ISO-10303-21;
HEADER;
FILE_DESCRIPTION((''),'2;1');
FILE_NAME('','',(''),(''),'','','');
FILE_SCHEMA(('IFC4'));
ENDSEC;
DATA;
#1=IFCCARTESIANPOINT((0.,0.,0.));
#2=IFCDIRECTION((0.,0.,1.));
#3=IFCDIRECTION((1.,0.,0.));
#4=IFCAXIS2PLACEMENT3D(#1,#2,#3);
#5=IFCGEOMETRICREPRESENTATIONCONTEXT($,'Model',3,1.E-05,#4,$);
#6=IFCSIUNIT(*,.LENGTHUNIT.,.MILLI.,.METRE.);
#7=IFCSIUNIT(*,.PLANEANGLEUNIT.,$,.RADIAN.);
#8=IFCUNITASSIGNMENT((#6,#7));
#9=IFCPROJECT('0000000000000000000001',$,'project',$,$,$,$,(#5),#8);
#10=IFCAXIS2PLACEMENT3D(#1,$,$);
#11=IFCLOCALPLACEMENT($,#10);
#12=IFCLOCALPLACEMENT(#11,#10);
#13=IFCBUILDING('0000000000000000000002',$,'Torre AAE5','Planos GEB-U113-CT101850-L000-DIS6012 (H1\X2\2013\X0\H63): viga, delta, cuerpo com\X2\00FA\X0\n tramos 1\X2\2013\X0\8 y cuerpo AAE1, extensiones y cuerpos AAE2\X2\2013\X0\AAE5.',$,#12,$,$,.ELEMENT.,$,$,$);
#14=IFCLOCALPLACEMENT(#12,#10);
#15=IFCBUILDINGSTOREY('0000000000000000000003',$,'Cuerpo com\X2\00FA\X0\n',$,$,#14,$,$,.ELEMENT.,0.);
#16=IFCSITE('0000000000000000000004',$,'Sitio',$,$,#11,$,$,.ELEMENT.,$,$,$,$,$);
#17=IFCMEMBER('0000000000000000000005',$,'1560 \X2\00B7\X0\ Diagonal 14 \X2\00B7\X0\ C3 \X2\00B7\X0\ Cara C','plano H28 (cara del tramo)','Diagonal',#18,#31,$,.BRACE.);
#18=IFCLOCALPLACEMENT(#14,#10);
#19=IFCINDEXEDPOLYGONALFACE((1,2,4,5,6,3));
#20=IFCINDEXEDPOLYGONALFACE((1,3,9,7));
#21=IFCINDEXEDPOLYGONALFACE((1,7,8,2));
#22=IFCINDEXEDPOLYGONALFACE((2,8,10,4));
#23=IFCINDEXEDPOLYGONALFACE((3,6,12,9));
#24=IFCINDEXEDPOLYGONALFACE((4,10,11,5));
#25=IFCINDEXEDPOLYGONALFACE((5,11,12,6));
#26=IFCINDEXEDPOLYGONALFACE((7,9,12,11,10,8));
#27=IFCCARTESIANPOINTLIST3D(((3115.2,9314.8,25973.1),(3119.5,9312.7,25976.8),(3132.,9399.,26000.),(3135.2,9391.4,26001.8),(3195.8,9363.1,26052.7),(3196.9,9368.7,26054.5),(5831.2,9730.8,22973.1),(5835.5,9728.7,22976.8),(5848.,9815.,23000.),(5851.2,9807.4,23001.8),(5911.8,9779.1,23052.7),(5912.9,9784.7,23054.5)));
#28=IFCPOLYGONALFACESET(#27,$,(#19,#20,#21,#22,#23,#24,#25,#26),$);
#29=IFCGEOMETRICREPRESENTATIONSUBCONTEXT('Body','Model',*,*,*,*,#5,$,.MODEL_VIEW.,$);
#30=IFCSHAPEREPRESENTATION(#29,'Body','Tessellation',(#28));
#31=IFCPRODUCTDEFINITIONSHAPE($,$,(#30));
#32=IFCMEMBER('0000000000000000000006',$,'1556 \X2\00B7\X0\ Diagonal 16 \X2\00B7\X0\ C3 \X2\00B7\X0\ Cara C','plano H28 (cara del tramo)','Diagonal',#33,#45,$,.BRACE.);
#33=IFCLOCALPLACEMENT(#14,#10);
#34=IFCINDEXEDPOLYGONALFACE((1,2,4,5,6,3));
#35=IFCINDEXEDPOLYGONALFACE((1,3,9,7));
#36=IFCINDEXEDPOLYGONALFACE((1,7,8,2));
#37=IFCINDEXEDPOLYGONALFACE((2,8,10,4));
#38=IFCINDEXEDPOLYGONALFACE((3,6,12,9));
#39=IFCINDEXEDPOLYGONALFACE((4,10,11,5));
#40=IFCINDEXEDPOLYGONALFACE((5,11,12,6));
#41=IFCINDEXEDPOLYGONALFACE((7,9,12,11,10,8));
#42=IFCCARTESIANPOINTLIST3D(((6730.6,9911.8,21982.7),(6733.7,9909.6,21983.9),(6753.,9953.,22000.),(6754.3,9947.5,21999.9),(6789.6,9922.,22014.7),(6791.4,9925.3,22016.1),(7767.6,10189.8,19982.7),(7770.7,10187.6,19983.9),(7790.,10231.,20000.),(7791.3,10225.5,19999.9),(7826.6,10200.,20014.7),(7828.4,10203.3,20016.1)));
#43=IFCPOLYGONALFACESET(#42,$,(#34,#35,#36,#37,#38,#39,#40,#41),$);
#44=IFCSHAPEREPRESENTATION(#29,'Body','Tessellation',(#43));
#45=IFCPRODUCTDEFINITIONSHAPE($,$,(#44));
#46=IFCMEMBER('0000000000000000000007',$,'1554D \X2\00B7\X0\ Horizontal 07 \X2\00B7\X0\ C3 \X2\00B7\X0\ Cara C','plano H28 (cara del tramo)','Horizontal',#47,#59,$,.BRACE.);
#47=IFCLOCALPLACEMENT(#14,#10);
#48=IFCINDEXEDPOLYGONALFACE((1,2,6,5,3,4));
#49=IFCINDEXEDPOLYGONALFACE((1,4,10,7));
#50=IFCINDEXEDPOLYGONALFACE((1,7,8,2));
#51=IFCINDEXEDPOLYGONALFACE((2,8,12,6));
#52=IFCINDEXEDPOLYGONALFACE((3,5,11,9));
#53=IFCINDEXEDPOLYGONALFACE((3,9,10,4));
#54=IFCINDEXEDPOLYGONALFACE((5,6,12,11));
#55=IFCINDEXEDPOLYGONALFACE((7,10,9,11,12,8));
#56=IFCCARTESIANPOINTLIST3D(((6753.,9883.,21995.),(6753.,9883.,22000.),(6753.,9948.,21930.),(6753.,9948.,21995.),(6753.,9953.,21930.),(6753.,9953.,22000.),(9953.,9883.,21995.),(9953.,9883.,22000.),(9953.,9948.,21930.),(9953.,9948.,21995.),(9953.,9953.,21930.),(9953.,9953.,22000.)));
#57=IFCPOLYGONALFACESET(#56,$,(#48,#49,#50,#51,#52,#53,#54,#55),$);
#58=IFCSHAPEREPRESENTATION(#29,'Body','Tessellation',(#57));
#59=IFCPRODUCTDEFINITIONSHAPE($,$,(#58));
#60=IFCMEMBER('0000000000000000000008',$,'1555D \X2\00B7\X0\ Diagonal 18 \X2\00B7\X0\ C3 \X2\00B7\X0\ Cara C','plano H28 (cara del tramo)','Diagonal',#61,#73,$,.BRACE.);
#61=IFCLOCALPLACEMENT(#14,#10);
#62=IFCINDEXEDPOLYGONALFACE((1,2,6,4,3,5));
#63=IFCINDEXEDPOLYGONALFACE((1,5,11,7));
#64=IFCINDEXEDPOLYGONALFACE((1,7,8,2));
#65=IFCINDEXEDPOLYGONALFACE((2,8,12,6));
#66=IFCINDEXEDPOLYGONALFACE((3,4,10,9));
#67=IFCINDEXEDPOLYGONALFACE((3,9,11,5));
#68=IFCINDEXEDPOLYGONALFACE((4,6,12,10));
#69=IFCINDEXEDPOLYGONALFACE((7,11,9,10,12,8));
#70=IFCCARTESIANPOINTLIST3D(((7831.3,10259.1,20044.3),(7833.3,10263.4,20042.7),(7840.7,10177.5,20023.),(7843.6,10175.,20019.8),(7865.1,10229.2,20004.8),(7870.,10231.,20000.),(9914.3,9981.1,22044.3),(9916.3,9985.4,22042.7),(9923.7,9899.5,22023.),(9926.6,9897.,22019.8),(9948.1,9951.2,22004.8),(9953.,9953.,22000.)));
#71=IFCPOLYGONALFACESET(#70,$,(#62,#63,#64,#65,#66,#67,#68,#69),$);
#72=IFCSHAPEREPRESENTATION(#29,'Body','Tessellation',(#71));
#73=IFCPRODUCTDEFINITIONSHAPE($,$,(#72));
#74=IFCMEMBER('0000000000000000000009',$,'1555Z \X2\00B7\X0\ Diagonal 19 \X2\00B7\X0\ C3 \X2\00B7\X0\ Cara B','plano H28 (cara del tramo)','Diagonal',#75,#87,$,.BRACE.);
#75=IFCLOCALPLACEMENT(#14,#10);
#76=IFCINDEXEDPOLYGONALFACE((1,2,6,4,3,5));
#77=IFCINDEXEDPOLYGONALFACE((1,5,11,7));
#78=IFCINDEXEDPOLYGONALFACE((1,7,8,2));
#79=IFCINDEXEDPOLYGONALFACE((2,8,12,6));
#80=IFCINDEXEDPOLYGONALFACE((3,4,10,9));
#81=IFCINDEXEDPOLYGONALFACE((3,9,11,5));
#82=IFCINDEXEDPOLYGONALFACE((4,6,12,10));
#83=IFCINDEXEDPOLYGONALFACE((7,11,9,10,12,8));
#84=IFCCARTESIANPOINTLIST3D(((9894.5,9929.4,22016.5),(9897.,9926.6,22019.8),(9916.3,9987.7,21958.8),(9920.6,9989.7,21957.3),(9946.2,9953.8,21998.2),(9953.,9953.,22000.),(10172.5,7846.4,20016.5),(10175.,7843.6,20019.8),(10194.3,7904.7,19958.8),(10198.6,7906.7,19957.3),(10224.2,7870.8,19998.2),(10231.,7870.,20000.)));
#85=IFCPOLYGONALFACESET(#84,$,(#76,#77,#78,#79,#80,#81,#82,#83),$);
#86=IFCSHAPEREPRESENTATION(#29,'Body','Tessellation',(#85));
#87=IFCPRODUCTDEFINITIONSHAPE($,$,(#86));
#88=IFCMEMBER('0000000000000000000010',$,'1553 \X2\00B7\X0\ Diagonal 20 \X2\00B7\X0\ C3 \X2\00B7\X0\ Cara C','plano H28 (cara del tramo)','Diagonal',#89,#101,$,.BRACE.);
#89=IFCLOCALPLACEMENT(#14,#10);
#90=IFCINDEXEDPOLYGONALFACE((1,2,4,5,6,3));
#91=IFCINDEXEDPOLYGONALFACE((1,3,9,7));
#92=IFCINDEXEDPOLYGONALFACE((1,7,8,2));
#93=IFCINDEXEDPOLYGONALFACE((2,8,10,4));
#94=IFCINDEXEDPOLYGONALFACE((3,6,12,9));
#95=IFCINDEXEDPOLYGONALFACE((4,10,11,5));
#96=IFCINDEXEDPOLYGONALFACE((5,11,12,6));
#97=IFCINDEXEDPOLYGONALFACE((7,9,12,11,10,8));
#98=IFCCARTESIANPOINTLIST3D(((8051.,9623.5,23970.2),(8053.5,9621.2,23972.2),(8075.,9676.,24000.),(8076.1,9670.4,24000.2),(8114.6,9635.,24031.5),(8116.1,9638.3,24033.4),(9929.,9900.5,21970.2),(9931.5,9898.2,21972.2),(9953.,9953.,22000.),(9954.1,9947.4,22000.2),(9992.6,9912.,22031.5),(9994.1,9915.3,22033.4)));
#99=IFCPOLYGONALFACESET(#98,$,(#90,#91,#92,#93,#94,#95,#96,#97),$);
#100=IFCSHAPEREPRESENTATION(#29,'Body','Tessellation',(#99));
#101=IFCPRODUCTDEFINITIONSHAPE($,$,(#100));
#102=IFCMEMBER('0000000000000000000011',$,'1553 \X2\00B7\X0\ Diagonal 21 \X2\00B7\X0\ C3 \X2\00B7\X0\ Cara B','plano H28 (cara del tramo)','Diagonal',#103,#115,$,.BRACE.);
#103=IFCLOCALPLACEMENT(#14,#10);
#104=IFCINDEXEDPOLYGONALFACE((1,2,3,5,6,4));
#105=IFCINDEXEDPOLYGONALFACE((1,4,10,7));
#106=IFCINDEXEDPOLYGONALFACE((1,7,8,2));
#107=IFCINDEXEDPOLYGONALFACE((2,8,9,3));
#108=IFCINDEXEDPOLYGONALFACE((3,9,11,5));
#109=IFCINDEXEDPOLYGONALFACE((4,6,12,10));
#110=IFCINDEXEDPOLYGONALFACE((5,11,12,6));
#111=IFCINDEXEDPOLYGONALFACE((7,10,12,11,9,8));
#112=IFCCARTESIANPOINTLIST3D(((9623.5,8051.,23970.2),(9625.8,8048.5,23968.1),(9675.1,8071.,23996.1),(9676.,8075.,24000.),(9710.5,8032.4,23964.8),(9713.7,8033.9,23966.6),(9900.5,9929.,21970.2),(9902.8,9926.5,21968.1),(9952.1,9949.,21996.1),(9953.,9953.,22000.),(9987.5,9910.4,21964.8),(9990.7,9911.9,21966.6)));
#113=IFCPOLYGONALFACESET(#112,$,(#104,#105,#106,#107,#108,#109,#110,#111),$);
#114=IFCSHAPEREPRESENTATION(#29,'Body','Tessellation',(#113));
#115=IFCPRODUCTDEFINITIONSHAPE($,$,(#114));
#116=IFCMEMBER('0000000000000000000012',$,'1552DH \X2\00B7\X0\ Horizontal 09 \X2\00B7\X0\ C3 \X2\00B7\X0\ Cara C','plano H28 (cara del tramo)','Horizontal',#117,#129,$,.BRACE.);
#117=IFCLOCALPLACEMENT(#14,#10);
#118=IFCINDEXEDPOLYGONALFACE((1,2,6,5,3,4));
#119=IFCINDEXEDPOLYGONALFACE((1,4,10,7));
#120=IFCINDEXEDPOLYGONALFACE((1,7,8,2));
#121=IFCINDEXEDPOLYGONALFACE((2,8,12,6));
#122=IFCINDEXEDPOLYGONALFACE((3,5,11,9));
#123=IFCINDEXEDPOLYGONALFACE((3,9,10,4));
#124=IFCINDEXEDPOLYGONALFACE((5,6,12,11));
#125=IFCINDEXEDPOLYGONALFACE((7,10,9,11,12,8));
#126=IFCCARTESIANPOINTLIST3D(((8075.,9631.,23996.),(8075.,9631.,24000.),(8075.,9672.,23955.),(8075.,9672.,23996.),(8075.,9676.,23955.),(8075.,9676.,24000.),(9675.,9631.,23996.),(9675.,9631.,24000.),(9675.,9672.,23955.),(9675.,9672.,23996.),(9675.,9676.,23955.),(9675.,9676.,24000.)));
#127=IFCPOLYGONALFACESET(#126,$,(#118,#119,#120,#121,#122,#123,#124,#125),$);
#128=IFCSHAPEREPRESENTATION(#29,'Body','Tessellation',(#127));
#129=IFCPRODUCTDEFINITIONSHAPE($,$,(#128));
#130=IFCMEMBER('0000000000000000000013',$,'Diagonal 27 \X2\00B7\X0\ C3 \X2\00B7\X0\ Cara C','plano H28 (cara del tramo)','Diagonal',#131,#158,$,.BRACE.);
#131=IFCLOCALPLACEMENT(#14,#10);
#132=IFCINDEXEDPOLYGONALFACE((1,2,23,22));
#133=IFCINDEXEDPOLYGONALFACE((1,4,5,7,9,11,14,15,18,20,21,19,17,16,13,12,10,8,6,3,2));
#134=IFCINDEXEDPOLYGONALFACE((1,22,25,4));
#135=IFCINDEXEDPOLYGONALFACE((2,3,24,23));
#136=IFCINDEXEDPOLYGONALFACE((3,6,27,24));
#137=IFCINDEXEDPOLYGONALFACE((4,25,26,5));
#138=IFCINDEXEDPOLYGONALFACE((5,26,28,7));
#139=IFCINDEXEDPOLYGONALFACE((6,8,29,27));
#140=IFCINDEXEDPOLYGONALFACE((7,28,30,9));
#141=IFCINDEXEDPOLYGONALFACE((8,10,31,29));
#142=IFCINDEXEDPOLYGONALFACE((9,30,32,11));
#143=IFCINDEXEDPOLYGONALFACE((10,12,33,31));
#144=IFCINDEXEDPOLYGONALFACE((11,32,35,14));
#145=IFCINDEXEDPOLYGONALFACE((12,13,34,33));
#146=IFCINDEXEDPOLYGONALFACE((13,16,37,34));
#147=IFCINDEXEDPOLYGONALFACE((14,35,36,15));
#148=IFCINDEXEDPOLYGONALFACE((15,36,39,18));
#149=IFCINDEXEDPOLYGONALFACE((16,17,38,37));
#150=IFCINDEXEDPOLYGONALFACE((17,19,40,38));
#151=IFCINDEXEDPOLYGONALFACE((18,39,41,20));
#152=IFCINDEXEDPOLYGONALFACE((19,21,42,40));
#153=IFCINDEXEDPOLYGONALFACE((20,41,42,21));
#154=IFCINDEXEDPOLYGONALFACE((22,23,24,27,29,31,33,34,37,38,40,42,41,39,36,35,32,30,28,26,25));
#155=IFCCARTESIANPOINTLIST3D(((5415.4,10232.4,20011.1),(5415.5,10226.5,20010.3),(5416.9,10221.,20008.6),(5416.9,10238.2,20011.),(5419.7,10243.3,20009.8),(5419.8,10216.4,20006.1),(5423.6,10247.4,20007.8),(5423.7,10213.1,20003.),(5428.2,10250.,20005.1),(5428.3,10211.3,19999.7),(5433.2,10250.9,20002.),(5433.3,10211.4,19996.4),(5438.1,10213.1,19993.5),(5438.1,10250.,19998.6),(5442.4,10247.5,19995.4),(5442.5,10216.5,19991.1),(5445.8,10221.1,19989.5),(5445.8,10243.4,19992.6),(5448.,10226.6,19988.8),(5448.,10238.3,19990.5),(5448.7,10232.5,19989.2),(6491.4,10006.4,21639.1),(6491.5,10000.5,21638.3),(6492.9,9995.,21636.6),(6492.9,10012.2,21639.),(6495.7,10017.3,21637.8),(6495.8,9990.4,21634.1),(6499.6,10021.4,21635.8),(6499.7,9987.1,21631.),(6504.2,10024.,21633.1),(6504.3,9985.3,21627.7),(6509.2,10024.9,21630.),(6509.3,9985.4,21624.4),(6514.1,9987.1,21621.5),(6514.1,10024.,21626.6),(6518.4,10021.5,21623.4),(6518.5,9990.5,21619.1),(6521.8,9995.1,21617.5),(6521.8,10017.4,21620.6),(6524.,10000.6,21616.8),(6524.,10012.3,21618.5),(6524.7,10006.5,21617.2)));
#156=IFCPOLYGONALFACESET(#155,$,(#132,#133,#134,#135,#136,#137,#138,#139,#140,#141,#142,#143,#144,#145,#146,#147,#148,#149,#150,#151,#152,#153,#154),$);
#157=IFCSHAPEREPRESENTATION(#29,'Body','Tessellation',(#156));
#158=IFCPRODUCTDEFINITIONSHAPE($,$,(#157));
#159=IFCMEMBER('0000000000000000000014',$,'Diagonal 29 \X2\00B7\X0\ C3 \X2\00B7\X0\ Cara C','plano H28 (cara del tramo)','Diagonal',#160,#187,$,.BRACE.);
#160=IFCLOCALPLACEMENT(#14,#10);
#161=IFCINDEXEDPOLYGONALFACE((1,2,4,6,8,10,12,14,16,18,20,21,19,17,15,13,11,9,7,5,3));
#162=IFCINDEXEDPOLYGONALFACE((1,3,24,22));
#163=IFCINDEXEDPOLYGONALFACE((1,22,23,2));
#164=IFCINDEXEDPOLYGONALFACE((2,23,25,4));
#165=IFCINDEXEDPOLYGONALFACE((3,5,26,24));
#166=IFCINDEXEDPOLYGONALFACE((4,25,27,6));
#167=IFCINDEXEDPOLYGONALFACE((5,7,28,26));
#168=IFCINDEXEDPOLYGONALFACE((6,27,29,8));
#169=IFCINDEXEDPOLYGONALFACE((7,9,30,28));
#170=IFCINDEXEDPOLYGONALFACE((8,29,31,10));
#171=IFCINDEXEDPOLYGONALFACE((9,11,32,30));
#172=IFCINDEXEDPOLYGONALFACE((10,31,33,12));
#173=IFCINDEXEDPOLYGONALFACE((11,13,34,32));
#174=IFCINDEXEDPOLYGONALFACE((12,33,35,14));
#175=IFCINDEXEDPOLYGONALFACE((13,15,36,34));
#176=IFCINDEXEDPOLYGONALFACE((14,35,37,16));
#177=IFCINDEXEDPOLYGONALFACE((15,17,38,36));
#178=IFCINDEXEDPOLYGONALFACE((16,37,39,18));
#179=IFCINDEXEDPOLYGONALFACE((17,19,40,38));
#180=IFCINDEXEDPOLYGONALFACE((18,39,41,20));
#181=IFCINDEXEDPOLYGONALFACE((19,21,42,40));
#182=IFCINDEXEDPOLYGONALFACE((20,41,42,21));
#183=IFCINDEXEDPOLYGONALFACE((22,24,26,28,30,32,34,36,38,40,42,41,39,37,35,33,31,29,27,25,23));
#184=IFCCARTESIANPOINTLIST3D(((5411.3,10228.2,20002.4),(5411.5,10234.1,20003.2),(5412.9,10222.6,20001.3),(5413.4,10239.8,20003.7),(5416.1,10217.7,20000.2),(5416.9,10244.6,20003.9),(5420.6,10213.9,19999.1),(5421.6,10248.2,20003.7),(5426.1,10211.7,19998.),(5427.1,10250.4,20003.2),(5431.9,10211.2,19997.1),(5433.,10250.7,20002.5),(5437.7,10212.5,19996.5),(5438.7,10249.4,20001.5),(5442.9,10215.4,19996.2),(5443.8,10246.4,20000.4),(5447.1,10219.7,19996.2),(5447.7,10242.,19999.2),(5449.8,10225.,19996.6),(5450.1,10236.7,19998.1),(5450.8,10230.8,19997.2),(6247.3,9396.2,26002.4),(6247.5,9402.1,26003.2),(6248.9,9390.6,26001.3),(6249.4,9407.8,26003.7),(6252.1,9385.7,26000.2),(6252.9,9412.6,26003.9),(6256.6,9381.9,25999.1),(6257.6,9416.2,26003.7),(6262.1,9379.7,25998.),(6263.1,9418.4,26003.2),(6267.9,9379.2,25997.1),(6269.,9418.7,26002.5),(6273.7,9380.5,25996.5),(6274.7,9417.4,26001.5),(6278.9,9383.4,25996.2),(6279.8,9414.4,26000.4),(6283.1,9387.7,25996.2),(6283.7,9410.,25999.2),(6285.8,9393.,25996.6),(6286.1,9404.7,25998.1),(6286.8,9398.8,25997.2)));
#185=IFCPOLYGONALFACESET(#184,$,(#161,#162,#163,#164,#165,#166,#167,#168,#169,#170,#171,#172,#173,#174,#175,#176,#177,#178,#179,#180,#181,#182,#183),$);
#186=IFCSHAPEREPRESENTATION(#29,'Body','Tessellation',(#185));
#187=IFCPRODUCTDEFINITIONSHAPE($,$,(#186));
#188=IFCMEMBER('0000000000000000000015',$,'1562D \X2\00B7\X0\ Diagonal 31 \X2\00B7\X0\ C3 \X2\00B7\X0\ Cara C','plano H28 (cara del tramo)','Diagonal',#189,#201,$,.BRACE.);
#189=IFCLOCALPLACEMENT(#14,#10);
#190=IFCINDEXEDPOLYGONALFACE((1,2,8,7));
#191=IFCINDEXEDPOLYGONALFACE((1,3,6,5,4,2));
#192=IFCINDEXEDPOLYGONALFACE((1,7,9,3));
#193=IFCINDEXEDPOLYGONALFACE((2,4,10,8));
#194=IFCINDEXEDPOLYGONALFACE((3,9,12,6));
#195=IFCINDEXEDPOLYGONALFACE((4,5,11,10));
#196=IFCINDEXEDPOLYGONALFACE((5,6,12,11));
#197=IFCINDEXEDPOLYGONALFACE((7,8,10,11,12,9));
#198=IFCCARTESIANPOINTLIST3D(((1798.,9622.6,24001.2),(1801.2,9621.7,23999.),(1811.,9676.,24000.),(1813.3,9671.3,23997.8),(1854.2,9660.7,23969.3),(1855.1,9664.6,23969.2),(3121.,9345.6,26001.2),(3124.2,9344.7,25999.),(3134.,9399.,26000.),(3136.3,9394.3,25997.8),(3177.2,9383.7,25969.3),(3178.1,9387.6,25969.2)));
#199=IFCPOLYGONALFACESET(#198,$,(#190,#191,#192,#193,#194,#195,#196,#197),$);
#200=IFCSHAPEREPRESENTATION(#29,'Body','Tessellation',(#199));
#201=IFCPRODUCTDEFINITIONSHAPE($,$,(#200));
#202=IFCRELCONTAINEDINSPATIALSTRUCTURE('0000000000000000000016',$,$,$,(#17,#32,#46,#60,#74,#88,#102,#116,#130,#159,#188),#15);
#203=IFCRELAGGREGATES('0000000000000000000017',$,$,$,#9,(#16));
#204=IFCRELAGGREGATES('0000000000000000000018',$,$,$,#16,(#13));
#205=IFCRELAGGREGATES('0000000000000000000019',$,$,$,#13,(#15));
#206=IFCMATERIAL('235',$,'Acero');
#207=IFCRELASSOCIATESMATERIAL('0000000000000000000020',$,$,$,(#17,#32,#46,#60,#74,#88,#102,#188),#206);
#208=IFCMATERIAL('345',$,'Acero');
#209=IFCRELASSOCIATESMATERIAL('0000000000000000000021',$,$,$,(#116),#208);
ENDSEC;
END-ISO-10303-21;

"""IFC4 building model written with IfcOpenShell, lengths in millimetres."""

from ifc_helpers import new_model, si_unit, frame, frame_2d, origin, origin_with_axes, place, context, subcontext, project, spatial, circle, l_section, extrude, material, element, save


model = new_model("IFC4")

# Units and contexts
model_context = context("Model", 3, precision=1e-05, world=origin_with_axes())
body_context = subcontext(model_context, "Body", "Model", "MODEL_VIEW")
ifc_project = project(units=[si_unit("LENGTHUNIT", "METRE", prefix="MILLI"), si_unit("PLANEANGLEUNIT", "RADIAN")], contexts=[model_context])

# Site, building, storey
site_placement = place(None, origin())
site = spatial("IfcSite", under=ifc_project, at=site_placement, Name="Sitio", CompositionType="ELEMENT")
building_placement = place(site_placement, origin())
building = spatial("IfcBuilding", under=site, at=building_placement, Name="Torre AAE5", Description="Planos GEB-U113-CT101850-L000-DIS6012 (H1–H63): viga, delta, cuerpo común tramos 1–8 y cuerpo AAE1, extensiones y cuerpos AAE2–AAE5.", CompositionType="ELEMENT")
storey_placement = place(building_placement, origin())
storey = spatial("IfcBuildingStorey", under=building, at=storey_placement, Name="Cuerpo común", CompositionType="ELEMENT", Elevation=0.0)

# Members
ifc_material_1 = material(Name="235", Category="Acero")
ifc_material_2 = material(Name="345", Category="Acero")
member_1_placement = place(storey_placement, frame((5848.0, 9815.0, 23000.0), z_axis=(-0.667628, -0.102258, 0.737439), x_axis=(-0.186465, -0.935984, -0.298603)))
element("IfcMember", 1, at=member_1_placement, inside=storey, material=ifc_material_1, Name="1560 · Diagonal 14 · C3 · Cara C", Description="plano H28 (cara del tramo)", ObjectType="Diagonal", PredefinedType="BRACE", context=body_context, shape_type="SweptSolid", body=[
    extrude(l_section(Depth=90.0, Width=90.0, Thickness=6.0, at=frame_2d((45.0, 45.0))), None, (0.0, 0.0, 1.0), 4068.1),
])
member_2_placement = place(storey_placement, frame((7790.0, 10231.0, 20000.0), z_axis=(-0.456839, -0.12247, 0.881078), x_axis=(-0.448371, -0.823752, -0.346982)))
element("IfcMember", 2, at=member_2_placement, inside=storey, material=ifc_material_1, Name="1556 · Diagonal 16 · C3 · Cara C", Description="plano H28 (cara del tramo)", ObjectType="Diagonal", PredefinedType="BRACE", context=body_context, shape_type="SweptSolid", body=[
    extrude(l_section(Depth=50.0, Width=50.0, Thickness=4.0, at=frame_2d((25.0, 25.0))), None, (0.0, 0.0, 1.0), 2269.9),
])
member_3_placement = place(storey_placement, frame((6753.0, 9953.0, 22000.0), z_axis=(1.0, 0.0, 0.0), x_axis=(0.0, -1.0, 0.0)))
element("IfcMember", 3, at=member_3_placement, inside=storey, material=ifc_material_1, Name="1554D · Horizontal 07 · C3 · Cara C", Description="plano H28 (cara del tramo)", ObjectType="Horizontal", PredefinedType="BRACE", context=body_context, shape_type="SweptSolid", body=[
    extrude(l_section(Depth=70.0, Width=70.0, Thickness=5.0, at=frame_2d((35.0, 35.0))), None, (0.0, 0.0, 1.0), 3200.0),
])
for number, where, z_axis, x_axis, name in (
    (4, (9953.0, 9953.0, 22000.0), (-0.718012, 0.095827, -0.689402), (-0.406815, -0.86146, 0.303955), "1555D · Diagonal 18 · C3 · Cara C"),
    (5, (9953.0, 9953.0, 22000.0), (0.095827, -0.718012, -0.689402), (-0.86146, -0.406815, 0.303955), "1555Z · Diagonal 19 · C3 · Cara B"),
):
    element("IfcMember", number, at=place(storey_placement, frame(where, z_axis=z_axis, x_axis=x_axis)), inside=storey, material=ifc_material_1, Name=name, Description="plano H28 (cara del tramo)", ObjectType="Diagonal", PredefinedType="BRACE", context=body_context, shape_type="SweptSolid", body=[
        extrude(l_section(Depth=65.0, Width=65.0, Thickness=5.0, at=frame_2d((32.5, 32.5))), None, (0.0, 0.0, 1.0), 2901.1),
    ])
for number, where, z_axis, x_axis, name in (
    (6, (9953.0, 9953.0, 22000.0), (-0.68106, -0.100455, 0.725304), (-0.369544, -0.807986, -0.458908), "1553 · Diagonal 20 · C3 · Cara C"),
    (7, (9953.0, 9953.0, 22000.0), (-0.100455, -0.68106, 0.725304), (-0.807986, -0.369544, -0.458908), "1553 · Diagonal 21 · C3 · Cara B"),
):
    element("IfcMember", number, at=place(storey_placement, frame(where, z_axis=z_axis, x_axis=x_axis)), inside=storey, material=ifc_material_1, Name=name, Description="plano H28 (cara del tramo)", ObjectType="Diagonal", PredefinedType="BRACE", context=body_context, shape_type="SweptSolid", body=[
        extrude(l_section(Depth=65.0, Width=65.0, Thickness=4.0, at=frame_2d((32.5, 32.5))), None, (0.0, 0.0, 1.0), 2757.5),
    ])
member_4_placement = place(storey_placement, frame((8075.0, 9676.0, 24000.0), z_axis=(1.0, 0.0, 0.0), x_axis=(0.0, -1.0, 0.0)))
element("IfcMember", 8, at=member_4_placement, inside=storey, material=ifc_material_2, Name="1552DH · Horizontal 09 · C3 · Cara C", Description="plano H28 (cara del tramo)", ObjectType="Horizontal", PredefinedType="BRACE", context=body_context, shape_type="SweptSolid", body=[
    extrude(l_section(Depth=45.0, Width=45.0, Thickness=4.0, at=frame_2d((22.5, 22.5))), None, (0.0, 0.0, 1.0), 1600.0),
])
member_5_placement = place(storey_placement, frame((6508.0, 10005.0, 21628.0), z_axis=(-0.547724, 0.115042, -0.828712), x_axis=(-0.41674, -0.896397, 0.150999)))
element("IfcMember", 9, at=member_5_placement, inside=storey, Name="Diagonal 27 · C3 · Cara C", Description="plano H28 (cara del tramo)", ObjectType="Diagonal", PredefinedType="BRACE", context=body_context, shape_type="SweptSolid", body=[
    extrude(circle(Radius=20.0), None, (0.0, 0.0, 1.0), 1964.5),
])
member_6_placement = place(storey_placement, frame((5431.0, 10231.0, 20000.0), z_axis=(0.136717, -0.136063, 0.981221), x_axis=(-0.518901, -0.853592, -0.046065)))
element("IfcMember", 10, at=member_6_placement, inside=storey, Name="Diagonal 29 · C3 · Cara C", Description="plano H28 (cara del tramo)", ObjectType="Diagonal", PredefinedType="BRACE", context=body_context, shape_type="SweptSolid", body=[
    extrude(circle(Radius=20.0), None, (0.0, 0.0, 1.0), 6114.8),
])
member_7_placement = place(storey_placement, frame((1811.0, 9676.0, 24000.0), z_axis=(0.548069, -0.114751, 0.828524), x_axis=(-0.236528, -0.971377, 0.021927)))
element("IfcMember", 11, at=member_7_placement, inside=storey, material=ifc_material_1, Name="1562D · Diagonal 31 · C3 · Cara C", Description="plano H28 (cara del tramo)", ObjectType="Diagonal", PredefinedType="BRACE", context=body_context, shape_type="SweptSolid", body=[
    extrude(l_section(Depth=55.0, Width=55.0, Thickness=4.0, at=frame_2d((27.5, 27.5))), None, (0.0, 0.0, 1.0), 2413.9),
])

save(model, "model.ifc")
